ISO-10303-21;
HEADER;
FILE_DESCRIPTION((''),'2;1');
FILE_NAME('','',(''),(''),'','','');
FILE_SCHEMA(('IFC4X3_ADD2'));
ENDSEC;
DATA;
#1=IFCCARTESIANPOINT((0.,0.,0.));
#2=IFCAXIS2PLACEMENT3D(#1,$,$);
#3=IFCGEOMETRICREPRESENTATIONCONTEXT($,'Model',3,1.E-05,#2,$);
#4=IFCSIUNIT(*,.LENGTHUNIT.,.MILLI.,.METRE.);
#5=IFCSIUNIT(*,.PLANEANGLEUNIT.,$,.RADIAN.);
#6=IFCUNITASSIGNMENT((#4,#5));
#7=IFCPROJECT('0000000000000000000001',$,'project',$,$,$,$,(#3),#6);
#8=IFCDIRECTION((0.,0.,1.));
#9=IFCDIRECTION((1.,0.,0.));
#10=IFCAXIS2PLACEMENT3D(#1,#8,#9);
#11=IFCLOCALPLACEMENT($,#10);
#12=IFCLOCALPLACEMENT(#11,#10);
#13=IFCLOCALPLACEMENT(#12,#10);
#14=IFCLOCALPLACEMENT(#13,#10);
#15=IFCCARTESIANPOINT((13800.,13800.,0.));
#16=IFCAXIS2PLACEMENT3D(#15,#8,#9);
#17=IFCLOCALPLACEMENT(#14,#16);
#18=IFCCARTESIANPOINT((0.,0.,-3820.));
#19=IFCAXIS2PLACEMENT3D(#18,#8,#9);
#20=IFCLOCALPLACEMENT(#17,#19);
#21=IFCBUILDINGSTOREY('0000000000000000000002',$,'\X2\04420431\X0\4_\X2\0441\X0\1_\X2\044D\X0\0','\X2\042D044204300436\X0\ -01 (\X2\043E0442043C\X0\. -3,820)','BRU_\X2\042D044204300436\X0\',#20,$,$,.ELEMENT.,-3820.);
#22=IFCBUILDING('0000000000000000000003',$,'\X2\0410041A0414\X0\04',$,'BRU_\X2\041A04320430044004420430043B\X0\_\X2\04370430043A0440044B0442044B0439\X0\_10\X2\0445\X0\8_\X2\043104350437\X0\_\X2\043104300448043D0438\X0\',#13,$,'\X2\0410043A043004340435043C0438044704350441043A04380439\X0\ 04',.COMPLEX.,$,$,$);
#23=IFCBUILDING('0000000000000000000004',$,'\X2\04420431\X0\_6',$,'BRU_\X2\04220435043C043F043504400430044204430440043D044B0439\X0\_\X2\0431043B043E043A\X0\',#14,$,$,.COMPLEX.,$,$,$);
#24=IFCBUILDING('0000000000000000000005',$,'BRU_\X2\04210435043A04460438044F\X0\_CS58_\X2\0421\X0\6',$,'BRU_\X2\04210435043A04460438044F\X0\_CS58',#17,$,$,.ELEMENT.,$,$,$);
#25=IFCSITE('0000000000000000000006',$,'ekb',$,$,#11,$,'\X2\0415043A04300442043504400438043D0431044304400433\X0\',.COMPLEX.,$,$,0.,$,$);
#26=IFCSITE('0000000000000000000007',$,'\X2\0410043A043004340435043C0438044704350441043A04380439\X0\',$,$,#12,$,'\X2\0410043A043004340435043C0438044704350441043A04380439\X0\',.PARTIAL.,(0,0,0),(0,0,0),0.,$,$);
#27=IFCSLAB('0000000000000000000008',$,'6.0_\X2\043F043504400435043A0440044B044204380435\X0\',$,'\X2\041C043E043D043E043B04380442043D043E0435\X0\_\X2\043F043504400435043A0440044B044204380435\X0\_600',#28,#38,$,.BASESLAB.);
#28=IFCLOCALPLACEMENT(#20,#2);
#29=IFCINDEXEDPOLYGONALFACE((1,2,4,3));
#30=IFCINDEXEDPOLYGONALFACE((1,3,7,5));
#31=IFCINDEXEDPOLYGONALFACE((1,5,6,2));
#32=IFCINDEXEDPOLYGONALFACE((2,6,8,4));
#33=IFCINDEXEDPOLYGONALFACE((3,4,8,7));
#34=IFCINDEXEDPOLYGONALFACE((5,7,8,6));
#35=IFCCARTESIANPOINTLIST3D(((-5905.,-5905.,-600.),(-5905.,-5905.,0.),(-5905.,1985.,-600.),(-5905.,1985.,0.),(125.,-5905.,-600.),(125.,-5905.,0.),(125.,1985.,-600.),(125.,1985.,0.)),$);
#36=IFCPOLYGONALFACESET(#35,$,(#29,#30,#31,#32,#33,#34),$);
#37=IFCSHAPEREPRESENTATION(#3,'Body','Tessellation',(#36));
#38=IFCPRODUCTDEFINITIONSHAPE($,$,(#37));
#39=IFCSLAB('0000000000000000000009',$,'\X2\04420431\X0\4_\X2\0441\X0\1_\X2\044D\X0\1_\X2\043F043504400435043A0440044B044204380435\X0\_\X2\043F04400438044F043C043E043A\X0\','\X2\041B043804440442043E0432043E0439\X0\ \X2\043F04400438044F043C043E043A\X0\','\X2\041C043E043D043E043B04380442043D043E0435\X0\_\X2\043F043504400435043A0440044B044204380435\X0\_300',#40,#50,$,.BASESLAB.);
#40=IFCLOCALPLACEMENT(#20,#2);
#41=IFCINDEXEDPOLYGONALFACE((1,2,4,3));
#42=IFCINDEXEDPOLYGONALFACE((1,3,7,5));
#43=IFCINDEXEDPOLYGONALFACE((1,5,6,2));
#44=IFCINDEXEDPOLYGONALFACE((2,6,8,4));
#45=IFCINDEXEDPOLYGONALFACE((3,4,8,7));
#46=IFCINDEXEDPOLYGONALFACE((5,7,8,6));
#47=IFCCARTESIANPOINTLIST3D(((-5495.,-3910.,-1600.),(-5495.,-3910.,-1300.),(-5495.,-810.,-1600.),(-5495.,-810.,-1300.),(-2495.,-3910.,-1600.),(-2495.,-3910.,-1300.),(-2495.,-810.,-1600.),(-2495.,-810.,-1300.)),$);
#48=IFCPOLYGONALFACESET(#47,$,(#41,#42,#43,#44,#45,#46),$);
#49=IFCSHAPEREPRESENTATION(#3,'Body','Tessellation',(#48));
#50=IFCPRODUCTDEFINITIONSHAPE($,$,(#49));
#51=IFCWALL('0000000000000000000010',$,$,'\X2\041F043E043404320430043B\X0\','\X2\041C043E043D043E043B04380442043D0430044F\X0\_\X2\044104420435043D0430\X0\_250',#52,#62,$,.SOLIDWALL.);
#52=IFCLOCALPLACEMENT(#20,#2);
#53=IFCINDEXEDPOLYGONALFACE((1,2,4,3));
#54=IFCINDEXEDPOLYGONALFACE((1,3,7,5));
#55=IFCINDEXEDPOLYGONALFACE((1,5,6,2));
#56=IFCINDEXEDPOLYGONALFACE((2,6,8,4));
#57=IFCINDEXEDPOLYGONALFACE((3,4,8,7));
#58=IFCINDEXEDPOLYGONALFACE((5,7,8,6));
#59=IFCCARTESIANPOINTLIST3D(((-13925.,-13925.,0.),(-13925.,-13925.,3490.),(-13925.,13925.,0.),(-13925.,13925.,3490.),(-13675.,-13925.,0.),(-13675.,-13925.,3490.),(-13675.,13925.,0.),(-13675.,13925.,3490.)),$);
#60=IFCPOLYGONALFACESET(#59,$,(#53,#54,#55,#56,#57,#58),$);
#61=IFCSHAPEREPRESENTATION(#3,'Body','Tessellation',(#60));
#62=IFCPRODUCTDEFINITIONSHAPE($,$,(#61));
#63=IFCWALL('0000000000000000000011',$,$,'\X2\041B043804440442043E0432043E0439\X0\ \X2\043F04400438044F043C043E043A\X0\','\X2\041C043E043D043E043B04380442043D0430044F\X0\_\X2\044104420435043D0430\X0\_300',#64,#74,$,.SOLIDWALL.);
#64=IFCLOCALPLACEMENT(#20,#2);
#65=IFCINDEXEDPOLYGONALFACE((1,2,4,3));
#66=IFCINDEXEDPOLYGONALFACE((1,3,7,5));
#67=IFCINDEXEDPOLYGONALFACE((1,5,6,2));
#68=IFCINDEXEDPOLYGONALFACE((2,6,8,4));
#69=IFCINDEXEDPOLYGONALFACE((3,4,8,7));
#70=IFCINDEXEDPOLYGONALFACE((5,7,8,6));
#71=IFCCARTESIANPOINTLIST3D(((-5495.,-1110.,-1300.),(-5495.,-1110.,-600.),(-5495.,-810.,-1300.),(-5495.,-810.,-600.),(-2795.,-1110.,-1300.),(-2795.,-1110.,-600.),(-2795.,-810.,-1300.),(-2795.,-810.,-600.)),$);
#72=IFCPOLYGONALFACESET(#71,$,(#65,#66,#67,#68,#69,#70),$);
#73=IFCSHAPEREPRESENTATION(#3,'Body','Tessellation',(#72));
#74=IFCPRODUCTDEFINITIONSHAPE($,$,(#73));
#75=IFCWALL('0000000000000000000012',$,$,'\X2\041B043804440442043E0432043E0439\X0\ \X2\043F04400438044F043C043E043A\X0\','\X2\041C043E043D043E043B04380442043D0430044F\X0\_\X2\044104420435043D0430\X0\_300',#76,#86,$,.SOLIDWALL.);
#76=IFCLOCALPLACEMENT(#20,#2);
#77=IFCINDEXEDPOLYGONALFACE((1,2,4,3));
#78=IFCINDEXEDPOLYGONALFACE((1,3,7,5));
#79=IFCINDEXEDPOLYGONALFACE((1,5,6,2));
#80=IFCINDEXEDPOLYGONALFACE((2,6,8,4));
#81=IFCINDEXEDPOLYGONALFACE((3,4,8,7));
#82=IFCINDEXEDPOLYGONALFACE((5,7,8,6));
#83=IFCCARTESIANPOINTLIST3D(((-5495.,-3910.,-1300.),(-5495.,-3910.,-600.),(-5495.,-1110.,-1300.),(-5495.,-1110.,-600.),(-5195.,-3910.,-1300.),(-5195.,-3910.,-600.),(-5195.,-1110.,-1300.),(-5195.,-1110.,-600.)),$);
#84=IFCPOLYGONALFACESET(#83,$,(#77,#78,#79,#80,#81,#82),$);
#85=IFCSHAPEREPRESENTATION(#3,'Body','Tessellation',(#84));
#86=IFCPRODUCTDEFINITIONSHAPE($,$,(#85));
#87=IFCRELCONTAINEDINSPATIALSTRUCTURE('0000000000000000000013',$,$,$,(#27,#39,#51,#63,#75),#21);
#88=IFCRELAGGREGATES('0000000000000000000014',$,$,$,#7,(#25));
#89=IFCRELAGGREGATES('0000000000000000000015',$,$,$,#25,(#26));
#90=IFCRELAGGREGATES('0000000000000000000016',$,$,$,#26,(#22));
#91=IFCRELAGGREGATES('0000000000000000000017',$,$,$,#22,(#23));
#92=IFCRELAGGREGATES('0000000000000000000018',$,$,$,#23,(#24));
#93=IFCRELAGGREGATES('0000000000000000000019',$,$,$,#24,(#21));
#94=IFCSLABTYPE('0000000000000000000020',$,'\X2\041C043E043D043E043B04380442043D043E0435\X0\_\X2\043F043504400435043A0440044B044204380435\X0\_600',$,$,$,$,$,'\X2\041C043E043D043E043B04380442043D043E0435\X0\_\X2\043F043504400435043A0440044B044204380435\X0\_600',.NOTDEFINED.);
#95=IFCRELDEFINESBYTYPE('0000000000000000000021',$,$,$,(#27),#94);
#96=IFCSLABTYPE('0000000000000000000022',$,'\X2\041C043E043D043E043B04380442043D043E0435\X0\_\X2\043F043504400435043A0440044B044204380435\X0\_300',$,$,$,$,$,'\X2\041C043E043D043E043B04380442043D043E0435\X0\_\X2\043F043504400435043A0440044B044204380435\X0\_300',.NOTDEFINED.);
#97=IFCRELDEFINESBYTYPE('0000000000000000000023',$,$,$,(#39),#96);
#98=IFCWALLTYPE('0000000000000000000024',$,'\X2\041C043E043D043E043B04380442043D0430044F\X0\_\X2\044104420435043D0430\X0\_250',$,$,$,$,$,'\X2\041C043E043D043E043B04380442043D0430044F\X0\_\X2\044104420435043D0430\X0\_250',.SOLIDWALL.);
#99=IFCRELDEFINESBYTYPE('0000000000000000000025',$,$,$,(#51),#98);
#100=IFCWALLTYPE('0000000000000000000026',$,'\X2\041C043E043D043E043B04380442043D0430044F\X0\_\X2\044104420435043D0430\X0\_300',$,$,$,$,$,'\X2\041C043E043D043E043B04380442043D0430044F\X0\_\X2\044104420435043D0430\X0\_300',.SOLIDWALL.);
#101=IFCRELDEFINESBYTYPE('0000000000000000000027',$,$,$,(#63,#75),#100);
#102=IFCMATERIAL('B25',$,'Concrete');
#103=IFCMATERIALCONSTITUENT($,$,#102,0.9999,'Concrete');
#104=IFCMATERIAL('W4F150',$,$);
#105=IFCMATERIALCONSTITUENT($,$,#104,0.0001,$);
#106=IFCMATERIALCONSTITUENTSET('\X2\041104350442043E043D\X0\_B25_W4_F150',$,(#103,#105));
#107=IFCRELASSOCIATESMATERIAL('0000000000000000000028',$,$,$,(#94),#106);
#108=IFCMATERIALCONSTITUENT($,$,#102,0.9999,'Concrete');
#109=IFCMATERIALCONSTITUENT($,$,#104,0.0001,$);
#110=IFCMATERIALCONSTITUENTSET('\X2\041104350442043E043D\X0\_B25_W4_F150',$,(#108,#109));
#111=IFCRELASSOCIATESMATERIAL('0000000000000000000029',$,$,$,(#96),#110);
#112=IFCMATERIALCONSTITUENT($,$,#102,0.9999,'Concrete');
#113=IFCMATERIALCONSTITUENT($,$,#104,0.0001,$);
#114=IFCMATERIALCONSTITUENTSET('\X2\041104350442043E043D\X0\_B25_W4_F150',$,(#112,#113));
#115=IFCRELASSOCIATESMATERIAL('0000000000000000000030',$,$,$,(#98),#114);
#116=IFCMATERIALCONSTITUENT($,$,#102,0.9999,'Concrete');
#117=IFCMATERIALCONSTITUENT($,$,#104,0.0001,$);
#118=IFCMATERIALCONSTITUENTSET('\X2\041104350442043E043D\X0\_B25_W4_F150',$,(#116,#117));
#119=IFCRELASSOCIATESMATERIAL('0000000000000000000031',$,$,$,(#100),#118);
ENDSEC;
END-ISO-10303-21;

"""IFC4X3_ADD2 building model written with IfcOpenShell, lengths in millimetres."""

from ifc_helpers import new_model, si_unit, frame, origin, origin_with_axes, origin_2d_with_axis, place, context, project, spatial, polyline, rectangle, outline, extrude, material, constituent, constituent_set, type_object, element, save


model = new_model("IFC4X3_ADD2")

# Units and contexts
model_context = context("Model", 3, precision=1e-05, world=origin())
ifc_project = project(units=[si_unit("LENGTHUNIT", "METRE", prefix="MILLI"), si_unit("PLANEANGLEUNIT", "RADIAN")], contexts=[model_context])

# Sites, buildings, storey
site_1_placement = place(None, origin_with_axes())
site_1 = spatial("IfcSite", under=ifc_project, at=site_1_placement, Name="ekb", LongName="Екатеринбург", CompositionType="COMPLEX", RefElevation=0.0)
site_2_placement = place(site_1_placement, origin_with_axes())
site_2 = spatial("IfcSite", under=site_1, at=site_2_placement, Name="Академический", LongName="Академический", CompositionType="PARTIAL", RefLatitude=(0, 0, 0), RefLongitude=(0, 0, 0), RefElevation=0.0)
building_1_placement = place(site_2_placement, origin_with_axes())
building_1 = spatial("IfcBuilding", under=site_2, at=building_1_placement, Name="АКД04", ObjectType="BRU_Квартал_закрытый_10х8_без_башни", LongName="Академический 04", CompositionType="COMPLEX")
building_2_placement = place(building_1_placement, origin_with_axes())
building_2 = spatial("IfcBuilding", under=building_1, at=building_2_placement, Name="тб_6", ObjectType="BRU_Температурный_блок", CompositionType="COMPLEX")
building_3_placement = place(building_2_placement, frame((13800.0, 13800.0, 0.0), z_axis=(0.0, 0.0, 1.0), x_axis=(1.0, 0.0, 0.0)))
building_3 = spatial("IfcBuilding", under=building_2, at=building_3_placement, Name="BRU_Секция_CS58_С6", ObjectType="BRU_Секция_CS58", CompositionType="ELEMENT")
storey_placement = place(building_3_placement, frame((0.0, 0.0, -3820.0), z_axis=(0.0, 0.0, 1.0), x_axis=(1.0, 0.0, 0.0)))
storey = spatial("IfcBuildingStorey", under=building_3, at=storey_placement, Name="тб4_с1_э0", Description="Этаж -01 (отм. -3,820)", ObjectType="BRU_Этаж", CompositionType="ELEMENT", Elevation=-3820.0)

# Shared definitions
ifc_material_1 = material(Name="B25", Category="Concrete")
ifc_material_2 = material(Name="W4F150")

# Slabs
ifc_constituent_1 = constituent(ifc_material_1, Category="Concrete", fraction=0.9999)
ifc_constituent_2 = constituent(ifc_material_2, fraction=0.0001)
ifc_constituent_set_1 = constituent_set(constituents=[ifc_constituent_1, ifc_constituent_2], Name="Бетон_B25_W4_F150")
slab_type_1 = type_object("IfcSlabType", Name="Монолитное_перекрытие_600", ElementType="Монолитное_перекрытие_600", PredefinedType="NOTDEFINED", material=ifc_constituent_set_1)
slab_1_placement = place(storey_placement, frame((0.0, 0.0, -600.0), z_axis=(0.0, 0.0, 1.0), x_axis=(1.0, 0.0, 0.0)))
element("IfcSlab", 1, at=slab_1_placement, inside=storey, type_object=slab_type_1, Name="6.0_перекрытие", ObjectType="Монолитное_перекрытие_600", PredefinedType="BASESLAB", context=model_context, shape_type="SweptSolid", body=[
    extrude(outline(polyline([(-5905.0, -5905.0), (125.0, -5905.0), (125.0, 1985.0), (-5905.0, 1985.0), (-5905.0, -5905.0)])), origin_with_axes(), (0.0, 0.0, 1.0), 600.0),
])
ifc_constituent_3 = constituent(ifc_material_1, Category="Concrete", fraction=0.9999)
ifc_constituent_4 = constituent(ifc_material_2, fraction=0.0001)
ifc_constituent_set_2 = constituent_set(constituents=[ifc_constituent_3, ifc_constituent_4], Name="Бетон_B25_W4_F150")
slab_type_2 = type_object("IfcSlabType", Name="Монолитное_перекрытие_300", ElementType="Монолитное_перекрытие_300", PredefinedType="NOTDEFINED", material=ifc_constituent_set_2)
slab_2_placement = place(storey_placement, frame((-3995.0, -2360.0, -1600.0), z_axis=(0.0, 0.0, 1.0), x_axis=(0.0, 1.0, 0.0)))
element("IfcSlab", 2, at=slab_2_placement, inside=storey, type_object=slab_type_2, Name="тб4_с1_э1_перекрытие_приямок", Description="Лифтовой приямок", ObjectType="Монолитное_перекрытие_300", PredefinedType="BASESLAB", context=model_context, shape_type="SweptSolid", body=[
    extrude(outline(polyline([(-1550.0, -1500.0), (-1550.0, 1500.0), (1550.0, 1500.0), (1550.0, -1500.0), (-1550.0, -1500.0)])), origin_with_axes(), (0.0, 0.0, 1.0), 300.0),
])

# Walls
ifc_constituent_5 = constituent(ifc_material_1, Category="Concrete", fraction=0.9999)
ifc_constituent_6 = constituent(ifc_material_2, fraction=0.0001)
ifc_constituent_set_3 = constituent_set(constituents=[ifc_constituent_5, ifc_constituent_6], Name="Бетон_B25_W4_F150")
wall_type_1 = type_object("IfcWallType", Name="Монолитная_стена_250", ElementType="Монолитная_стена_250", PredefinedType="SOLIDWALL", material=ifc_constituent_set_3)
wall_1_placement = place(storey_placement, frame((-13800.0, 13925.0, 0.0), z_axis=(0.0, 0.0, 1.0), x_axis=(0.0, -1.0, 0.0)))
element("IfcWall", 3, at=wall_1_placement, inside=storey, type_object=wall_type_1, Description="Подвал", ObjectType="Монолитная_стена_250", PredefinedType="SOLIDWALL", context=model_context, shape_type="SweptSolid", body=[
    extrude(rectangle(XDim=27850.0, YDim=250.0, at=origin_2d_with_axis()), frame((13925.0, 0.0, 0.0), z_axis=(0.0, 0.0, 1.0), x_axis=(1.0, 0.0, 0.0)), (0.0, 0.0, 1.0), 3490.0),
])
ifc_constituent_7 = constituent(ifc_material_1, Category="Concrete", fraction=0.9999)
ifc_constituent_8 = constituent(ifc_material_2, fraction=0.0001)
ifc_constituent_set_4 = constituent_set(constituents=[ifc_constituent_7, ifc_constituent_8], Name="Бетон_B25_W4_F150")
wall_type_2 = type_object("IfcWallType", Name="Монолитная_стена_300", ElementType="Монолитная_стена_300", PredefinedType="SOLIDWALL", material=ifc_constituent_set_4)
wall_2_placement = place(storey_placement, frame((-2795.0, -960.0, -1300.0), z_axis=(0.0, 0.0, 1.0), x_axis=(-1.0, 0.0, 0.0)))
element("IfcWall", 4, at=wall_2_placement, inside=storey, type_object=wall_type_2, Description="Лифтовой приямок", ObjectType="Монолитная_стена_300", PredefinedType="SOLIDWALL", context=model_context, shape_type="SweptSolid", body=[
    extrude(rectangle(XDim=2700.0, YDim=300.0, at=origin_2d_with_axis()), frame((1350.0, 0.0, 0.0), z_axis=(0.0, 0.0, 1.0), x_axis=(1.0, 0.0, 0.0)), (0.0, 0.0, 1.0), 700.0),
])
wall_3_placement = place(storey_placement, frame((-5345.0, -1110.0, -1300.0), z_axis=(0.0, 0.0, 1.0), x_axis=(0.0, -1.0, 0.0)))
element("IfcWall", 5, at=wall_3_placement, inside=storey, type_object=wall_type_2, Description="Лифтовой приямок", ObjectType="Монолитная_стена_300", PredefinedType="SOLIDWALL", context=model_context, shape_type="SweptSolid", body=[
    extrude(rectangle(XDim=2800.0, YDim=300.0, at=origin_2d_with_axis()), frame((1400.0, 0.0, 0.0), z_axis=(0.0, 0.0, 1.0), x_axis=(1.0, 0.0, 0.0)), (0.0, 0.0, 1.0), 700.0),
])

save(model, "model.ifc")
